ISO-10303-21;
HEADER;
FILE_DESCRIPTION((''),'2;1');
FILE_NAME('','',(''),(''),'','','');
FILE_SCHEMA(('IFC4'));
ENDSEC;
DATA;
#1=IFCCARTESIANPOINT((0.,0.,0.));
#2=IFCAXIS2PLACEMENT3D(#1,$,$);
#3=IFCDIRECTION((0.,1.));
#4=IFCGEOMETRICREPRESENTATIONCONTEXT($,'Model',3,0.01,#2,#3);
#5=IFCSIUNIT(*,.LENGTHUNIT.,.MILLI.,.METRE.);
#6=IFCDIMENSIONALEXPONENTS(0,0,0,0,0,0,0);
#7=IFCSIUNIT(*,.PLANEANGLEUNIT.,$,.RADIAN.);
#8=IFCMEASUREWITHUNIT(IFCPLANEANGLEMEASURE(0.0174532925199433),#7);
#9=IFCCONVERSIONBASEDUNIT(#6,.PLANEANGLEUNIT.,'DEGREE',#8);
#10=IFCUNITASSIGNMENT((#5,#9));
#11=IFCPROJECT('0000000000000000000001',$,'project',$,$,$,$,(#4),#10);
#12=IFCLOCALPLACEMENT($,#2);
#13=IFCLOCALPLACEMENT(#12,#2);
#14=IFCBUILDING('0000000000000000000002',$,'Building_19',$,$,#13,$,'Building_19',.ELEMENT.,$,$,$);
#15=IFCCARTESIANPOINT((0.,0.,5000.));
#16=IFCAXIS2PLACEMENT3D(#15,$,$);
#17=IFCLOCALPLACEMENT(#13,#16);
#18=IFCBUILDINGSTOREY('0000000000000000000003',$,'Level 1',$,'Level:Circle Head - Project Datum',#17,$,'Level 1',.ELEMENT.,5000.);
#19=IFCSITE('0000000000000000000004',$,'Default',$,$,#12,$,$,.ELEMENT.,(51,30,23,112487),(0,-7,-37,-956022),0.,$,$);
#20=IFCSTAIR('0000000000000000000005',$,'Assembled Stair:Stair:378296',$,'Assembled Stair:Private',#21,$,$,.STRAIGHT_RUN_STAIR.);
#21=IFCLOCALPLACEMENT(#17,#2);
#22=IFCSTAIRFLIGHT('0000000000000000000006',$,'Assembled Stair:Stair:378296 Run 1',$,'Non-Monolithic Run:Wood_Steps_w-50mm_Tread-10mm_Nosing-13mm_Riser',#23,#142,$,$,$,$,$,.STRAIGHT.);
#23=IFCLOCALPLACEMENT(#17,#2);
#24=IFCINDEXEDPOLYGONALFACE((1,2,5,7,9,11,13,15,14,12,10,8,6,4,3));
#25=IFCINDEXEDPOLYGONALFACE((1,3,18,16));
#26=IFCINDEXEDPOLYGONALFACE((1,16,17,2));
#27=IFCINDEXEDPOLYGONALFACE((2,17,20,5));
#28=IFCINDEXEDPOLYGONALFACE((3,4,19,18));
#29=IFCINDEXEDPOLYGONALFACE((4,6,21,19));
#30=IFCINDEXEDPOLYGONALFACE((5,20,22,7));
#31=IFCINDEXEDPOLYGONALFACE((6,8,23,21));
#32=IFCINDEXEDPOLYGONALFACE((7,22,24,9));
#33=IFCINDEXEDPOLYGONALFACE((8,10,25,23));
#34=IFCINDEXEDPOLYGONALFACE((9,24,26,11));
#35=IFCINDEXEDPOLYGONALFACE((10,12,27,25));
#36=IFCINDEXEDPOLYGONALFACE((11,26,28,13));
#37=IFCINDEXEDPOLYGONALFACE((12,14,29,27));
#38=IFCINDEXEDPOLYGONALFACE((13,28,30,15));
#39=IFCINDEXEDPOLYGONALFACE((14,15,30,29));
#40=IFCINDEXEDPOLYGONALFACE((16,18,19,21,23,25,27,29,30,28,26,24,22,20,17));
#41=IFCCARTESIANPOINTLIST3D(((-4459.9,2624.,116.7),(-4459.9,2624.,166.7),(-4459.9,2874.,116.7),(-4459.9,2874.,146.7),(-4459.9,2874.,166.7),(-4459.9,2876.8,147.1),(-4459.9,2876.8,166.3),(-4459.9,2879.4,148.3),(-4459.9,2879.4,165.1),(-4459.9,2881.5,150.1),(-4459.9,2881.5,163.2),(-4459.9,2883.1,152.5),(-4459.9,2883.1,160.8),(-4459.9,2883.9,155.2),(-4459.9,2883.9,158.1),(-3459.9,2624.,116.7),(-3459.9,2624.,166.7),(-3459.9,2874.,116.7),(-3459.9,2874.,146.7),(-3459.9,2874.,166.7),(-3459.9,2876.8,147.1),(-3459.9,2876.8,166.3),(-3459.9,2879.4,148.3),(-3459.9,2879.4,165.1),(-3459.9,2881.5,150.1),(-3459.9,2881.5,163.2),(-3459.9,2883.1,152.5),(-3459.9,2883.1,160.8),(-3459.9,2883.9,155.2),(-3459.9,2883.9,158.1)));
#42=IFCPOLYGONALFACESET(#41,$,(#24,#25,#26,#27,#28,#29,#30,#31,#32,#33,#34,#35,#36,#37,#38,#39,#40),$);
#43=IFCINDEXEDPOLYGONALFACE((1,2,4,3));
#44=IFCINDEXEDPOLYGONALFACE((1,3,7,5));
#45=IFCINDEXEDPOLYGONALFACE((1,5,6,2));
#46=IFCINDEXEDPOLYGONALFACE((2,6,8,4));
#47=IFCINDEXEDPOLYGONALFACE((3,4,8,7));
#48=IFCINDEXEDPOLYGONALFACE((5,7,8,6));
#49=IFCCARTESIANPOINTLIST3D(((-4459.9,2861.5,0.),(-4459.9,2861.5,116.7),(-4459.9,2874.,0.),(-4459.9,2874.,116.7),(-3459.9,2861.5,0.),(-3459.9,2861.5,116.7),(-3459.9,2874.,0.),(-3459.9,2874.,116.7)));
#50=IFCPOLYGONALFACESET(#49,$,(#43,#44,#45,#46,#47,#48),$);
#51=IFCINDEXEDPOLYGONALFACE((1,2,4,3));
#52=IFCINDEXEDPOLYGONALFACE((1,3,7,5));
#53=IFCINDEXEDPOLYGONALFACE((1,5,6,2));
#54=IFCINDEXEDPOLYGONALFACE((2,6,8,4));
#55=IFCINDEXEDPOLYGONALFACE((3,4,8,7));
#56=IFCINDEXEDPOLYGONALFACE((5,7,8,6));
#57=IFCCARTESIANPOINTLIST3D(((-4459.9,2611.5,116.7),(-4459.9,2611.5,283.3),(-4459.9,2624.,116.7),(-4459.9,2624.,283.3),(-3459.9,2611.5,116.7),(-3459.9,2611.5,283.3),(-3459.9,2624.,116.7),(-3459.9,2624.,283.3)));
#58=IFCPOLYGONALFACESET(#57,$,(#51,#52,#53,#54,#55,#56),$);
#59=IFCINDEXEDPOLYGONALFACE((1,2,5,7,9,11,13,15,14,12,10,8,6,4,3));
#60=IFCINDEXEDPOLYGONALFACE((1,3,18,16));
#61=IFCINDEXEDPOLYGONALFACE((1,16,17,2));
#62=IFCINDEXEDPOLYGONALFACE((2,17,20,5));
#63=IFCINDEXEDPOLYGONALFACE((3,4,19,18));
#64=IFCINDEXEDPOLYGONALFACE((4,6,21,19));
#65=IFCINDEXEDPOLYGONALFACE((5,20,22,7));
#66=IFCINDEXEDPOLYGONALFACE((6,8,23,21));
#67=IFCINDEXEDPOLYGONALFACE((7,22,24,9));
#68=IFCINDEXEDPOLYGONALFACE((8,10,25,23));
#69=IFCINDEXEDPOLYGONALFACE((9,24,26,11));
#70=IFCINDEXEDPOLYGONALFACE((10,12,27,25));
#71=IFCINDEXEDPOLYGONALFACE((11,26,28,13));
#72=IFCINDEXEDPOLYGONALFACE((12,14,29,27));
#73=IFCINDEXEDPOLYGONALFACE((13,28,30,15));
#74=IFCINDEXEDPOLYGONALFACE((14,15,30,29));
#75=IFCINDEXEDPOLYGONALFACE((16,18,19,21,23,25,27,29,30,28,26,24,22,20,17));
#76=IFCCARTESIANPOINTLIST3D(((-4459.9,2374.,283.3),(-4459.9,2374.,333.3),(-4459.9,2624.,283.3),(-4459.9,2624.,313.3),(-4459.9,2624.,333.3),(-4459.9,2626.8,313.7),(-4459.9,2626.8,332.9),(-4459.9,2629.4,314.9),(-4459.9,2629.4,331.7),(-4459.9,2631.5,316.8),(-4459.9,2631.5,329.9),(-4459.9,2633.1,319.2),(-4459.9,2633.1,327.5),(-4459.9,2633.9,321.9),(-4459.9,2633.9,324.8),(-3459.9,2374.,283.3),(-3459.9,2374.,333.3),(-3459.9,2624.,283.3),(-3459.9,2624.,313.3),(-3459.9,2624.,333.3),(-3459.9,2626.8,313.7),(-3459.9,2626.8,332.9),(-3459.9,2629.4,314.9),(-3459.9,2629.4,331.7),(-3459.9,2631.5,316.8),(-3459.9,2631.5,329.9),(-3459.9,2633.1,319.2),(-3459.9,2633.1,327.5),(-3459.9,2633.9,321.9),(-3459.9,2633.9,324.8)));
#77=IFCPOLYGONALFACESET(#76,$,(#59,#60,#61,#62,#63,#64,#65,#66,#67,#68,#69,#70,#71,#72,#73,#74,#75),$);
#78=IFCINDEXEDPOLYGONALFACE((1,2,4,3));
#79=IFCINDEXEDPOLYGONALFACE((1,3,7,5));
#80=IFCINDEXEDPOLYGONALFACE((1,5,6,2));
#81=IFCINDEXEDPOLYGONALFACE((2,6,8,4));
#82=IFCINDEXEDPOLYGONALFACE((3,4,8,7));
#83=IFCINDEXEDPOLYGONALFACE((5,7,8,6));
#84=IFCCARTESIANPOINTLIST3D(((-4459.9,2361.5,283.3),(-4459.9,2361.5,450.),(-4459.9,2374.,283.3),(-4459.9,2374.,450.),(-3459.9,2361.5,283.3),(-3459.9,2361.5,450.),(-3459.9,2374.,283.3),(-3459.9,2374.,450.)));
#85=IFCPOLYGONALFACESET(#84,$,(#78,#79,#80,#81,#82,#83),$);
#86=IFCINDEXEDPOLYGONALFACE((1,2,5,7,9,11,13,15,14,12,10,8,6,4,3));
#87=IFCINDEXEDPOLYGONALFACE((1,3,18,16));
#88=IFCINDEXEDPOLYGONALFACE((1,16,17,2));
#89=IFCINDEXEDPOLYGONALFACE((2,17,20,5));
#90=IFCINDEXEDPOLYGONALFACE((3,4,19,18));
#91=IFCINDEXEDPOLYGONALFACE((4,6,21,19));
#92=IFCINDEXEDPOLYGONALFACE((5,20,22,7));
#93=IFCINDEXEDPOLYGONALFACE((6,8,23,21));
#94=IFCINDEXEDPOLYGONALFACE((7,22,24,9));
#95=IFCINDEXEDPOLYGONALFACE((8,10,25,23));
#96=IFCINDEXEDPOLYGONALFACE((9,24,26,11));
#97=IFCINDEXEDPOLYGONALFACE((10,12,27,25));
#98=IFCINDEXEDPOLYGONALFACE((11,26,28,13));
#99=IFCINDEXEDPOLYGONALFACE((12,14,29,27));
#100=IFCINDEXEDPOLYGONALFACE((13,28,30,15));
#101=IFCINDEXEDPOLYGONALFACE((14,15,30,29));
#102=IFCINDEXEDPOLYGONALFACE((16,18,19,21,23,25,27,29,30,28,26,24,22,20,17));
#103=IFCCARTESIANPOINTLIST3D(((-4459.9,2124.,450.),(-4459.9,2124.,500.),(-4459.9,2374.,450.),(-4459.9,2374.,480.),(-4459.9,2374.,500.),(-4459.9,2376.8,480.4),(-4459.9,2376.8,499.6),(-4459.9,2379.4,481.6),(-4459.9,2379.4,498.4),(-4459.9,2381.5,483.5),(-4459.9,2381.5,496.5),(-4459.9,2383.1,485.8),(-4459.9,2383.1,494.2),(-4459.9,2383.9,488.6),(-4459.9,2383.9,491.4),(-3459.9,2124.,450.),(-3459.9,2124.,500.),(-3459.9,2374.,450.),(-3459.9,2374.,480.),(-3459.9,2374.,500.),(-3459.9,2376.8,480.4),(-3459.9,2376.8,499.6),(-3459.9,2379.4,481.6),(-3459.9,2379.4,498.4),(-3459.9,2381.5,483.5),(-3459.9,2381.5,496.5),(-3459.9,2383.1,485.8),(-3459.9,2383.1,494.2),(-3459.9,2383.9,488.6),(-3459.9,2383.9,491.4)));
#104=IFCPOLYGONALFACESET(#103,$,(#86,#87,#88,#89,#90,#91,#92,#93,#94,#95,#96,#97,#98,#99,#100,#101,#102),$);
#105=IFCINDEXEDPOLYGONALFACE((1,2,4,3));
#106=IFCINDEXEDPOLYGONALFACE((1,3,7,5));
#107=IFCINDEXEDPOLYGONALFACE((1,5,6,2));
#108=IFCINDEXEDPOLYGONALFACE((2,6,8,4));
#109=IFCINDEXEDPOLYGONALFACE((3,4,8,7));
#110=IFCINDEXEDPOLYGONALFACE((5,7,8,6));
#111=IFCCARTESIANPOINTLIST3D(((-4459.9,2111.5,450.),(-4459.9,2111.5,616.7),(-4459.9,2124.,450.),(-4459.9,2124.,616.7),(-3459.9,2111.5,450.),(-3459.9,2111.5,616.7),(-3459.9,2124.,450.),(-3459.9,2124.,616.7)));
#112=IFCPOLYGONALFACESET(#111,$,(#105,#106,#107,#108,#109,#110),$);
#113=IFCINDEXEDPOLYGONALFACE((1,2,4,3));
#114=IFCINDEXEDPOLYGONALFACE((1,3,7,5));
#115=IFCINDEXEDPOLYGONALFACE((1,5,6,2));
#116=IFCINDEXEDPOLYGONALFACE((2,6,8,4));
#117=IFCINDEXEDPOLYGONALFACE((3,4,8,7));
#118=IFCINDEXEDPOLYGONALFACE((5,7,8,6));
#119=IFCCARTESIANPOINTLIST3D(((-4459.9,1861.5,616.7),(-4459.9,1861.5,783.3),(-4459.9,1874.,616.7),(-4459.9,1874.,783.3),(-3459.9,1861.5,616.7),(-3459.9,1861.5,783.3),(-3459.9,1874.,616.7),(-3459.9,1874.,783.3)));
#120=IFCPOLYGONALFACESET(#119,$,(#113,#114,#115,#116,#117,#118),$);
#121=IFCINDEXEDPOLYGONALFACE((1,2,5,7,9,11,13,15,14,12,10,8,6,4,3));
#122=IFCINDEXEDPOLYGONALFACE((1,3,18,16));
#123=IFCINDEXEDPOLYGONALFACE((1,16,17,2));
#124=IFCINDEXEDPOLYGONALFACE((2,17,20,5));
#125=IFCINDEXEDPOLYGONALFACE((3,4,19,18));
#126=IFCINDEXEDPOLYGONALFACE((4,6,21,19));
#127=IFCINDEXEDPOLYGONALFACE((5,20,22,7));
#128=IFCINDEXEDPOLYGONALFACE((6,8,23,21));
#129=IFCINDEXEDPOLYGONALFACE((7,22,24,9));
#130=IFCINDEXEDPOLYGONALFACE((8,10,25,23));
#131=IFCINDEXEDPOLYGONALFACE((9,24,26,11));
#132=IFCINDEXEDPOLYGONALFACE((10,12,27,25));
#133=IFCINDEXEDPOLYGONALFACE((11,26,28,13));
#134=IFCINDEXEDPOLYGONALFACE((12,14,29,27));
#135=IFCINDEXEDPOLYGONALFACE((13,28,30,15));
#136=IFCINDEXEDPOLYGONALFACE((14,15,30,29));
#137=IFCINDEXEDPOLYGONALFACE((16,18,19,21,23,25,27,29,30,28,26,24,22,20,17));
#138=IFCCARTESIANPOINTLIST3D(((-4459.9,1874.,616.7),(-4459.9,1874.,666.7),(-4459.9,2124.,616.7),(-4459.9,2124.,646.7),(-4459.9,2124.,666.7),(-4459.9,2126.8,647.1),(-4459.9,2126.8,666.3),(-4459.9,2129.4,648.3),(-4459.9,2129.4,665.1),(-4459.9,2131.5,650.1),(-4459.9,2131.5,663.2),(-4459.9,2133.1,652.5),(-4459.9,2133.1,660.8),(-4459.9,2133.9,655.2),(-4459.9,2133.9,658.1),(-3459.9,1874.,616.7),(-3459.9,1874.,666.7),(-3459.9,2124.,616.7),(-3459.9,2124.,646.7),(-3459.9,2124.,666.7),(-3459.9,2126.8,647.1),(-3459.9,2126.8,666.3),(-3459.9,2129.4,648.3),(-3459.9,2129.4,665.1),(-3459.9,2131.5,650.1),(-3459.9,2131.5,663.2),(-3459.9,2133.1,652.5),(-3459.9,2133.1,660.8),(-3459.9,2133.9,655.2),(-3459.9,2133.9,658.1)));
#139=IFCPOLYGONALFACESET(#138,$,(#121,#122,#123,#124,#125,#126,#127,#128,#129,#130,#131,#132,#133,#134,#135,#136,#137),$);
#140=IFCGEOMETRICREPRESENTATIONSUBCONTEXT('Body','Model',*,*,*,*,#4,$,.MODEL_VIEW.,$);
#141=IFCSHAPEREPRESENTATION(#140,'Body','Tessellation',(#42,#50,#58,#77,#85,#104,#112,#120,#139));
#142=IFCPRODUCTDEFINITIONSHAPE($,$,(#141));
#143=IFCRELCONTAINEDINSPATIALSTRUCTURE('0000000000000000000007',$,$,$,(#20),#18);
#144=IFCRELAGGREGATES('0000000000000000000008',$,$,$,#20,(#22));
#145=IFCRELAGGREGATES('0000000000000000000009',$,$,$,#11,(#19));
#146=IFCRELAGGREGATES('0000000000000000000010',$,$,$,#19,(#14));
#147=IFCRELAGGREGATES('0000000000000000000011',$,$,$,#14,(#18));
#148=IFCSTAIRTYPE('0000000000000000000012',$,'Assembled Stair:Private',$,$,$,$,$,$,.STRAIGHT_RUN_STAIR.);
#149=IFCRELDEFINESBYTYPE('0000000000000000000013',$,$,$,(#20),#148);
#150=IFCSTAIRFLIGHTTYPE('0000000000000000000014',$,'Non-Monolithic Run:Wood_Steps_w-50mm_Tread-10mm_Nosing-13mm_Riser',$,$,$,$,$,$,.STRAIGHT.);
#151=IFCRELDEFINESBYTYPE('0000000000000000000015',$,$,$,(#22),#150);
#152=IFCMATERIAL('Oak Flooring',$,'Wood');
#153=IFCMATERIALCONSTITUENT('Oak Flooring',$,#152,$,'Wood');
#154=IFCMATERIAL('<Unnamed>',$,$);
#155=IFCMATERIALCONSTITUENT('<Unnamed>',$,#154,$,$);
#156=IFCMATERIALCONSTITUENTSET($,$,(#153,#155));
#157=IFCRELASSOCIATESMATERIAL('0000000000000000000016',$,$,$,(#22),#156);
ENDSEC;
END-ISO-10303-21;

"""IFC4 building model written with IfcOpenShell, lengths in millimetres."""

from ifc_helpers import new_model, entity, si_unit, converted_unit, direction, frame, origin, place, context, subcontext, project, spatial, line, arc, indexed_curve, outline, extrude, material, constituent, constituent_set, type_object, element, aggregate, save


model = new_model("IFC4")

# Units and contexts
model_context = context("Model", 3, precision=0.01, world=origin(), true_north=direction((0.0, 1.0)))
body_context = subcontext(model_context, "Body", "Model", "MODEL_VIEW")
ifc_project = project(units=[si_unit("LENGTHUNIT", "METRE", prefix="MILLI"), converted_unit("PLANEANGLEUNIT", "DEGREE", entity("IfcPlaneAngleMeasure", 0.0174532925199433), si_unit("PLANEANGLEUNIT", "RADIAN"), dimensions=[0, 0, 0, 0, 0, 0, 0])], contexts=[model_context])

# Site, building, storey
site_placement = place(None, origin())
site = spatial("IfcSite", under=ifc_project, at=site_placement, Name="Default", CompositionType="ELEMENT", RefLatitude=(51, 30, 23, 112487), RefLongitude=(0, -7, -37, -956022), RefElevation=0.0)
building_placement = place(site_placement, origin())
building = spatial("IfcBuilding", under=site, at=building_placement, Name="Building_19", LongName="Building_19", CompositionType="ELEMENT")
storey_placement = place(building_placement, frame((0.0, 0.0, 5000.0)))
storey = spatial("IfcBuildingStorey", under=building, at=storey_placement, Name="Level 1", ObjectType="Level:Circle Head - Project Datum", LongName="Level 1", CompositionType="ELEMENT", Elevation=5000.0)

# Stair
stair_type = type_object("IfcStairType", Name="Assembled Stair:Private", PredefinedType="STRAIGHT_RUN_STAIR")
ifc_material_1 = material(Name="<Unnamed>")
stair_1_placement = place(storey_placement, origin())
stair_1 = element("IfcStair", 1, at=stair_1_placement, inside=storey, type_object=stair_type, Name="Assembled Stair:Stair:378296", ObjectType="Assembled Stair:Private", PredefinedType="STRAIGHT_RUN_STAIR")

# Stair flight
ifc_material_2 = material(Name="Oak Flooring", Category="Wood")
stair_flight_type = type_object("IfcStairFlightType", Name="Non-Monolithic Run:Wood_Steps_w-50mm_Tread-10mm_Nosing-13mm_Riser", PredefinedType="STRAIGHT")
ifc_constituent_1 = constituent(ifc_material_2, Name="Oak Flooring", Category="Wood")
ifc_constituent_2 = constituent(ifc_material_1, Name="<Unnamed>")
ifc_constituent_set_1 = constituent_set(constituents=[ifc_constituent_1, ifc_constituent_2])
stair_flight_1_placement = place(stair_1_placement, origin())
stair_flight_1 = element("IfcStairFlight", 2, at=stair_flight_1_placement, type_object=stair_flight_type, material=ifc_constituent_set_1, Name="Assembled Stair:Stair:378296 Run 1", ObjectType="Non-Monolithic Run:Wood_Steps_w-50mm_Tread-10mm_Nosing-13mm_Riser", PredefinedType="STRAIGHT", context=body_context, shape_type="SweptSolid", body=[
    extrude(outline(indexed_curve([(-24.0, -150.0), (26.0, -150.0), (26.0, 100.0), (-4.0, 100.0), (-14.0, 110.0), (-24.0, 100.0)], segments=[line(1, 2, 3, 4), arc(4, 5, 6), line(6, 1)], self_intersect=False)), frame((-4459.9, 2774.0, 142.7), z_axis=(1.0, 0.0, 0.0), x_axis=(0.0, 0.0, -1.0)), (0.0, 0.0, 1.0), 1000.0),
    extrude(outline(indexed_curve([(-500.0, -6.3), (500.0, -6.3), (500.0, 6.2), (-500.0, 6.2), (-500.0, -6.3)], self_intersect=False)), frame((-3959.9, 2867.7, 0.0)), (0.0, 0.0, 1.0), 116.7),
    extrude(outline(indexed_curve([(-500.0, -6.2), (500.0, -6.2), (500.0, 6.3), (-500.0, 6.3), (-500.0, -6.2)], self_intersect=False)), frame((-3959.9, 2617.7, 116.7)), (0.0, 0.0, 1.0), 166.7),
    extrude(outline(indexed_curve([(-24.0, -150.0), (26.0, -150.0), (26.0, 100.0), (-4.0, 100.0), (-14.0, 110.0), (-24.0, 100.0)], segments=[line(1, 2, 3, 4), arc(4, 5, 6), line(6, 1)], self_intersect=False)), frame((-4459.9, 2524.0, 309.3), z_axis=(1.0, 0.0, 0.0), x_axis=(0.0, 0.0, -1.0)), (0.0, 0.0, 1.0), 1000.0),
    extrude(outline(indexed_curve([(-500.0, -6.2), (500.0, -6.2), (500.0, 6.2), (-500.0, 6.2), (-500.0, -6.2)], self_intersect=False)), frame((-3959.9, 2367.7, 283.3)), (0.0, 0.0, 1.0), 166.7),
    extrude(outline(indexed_curve([(-24.0, -150.0), (26.0, -150.0), (26.0, 100.0), (-4.0, 100.0), (-14.0, 110.0), (-24.0, 100.0)], segments=[line(1, 2, 3, 4), arc(4, 5, 6), line(6, 1)], self_intersect=False)), frame((-4459.9, 2274.0, 476.0), z_axis=(1.0, 0.0, 0.0), x_axis=(0.0, 0.0, -1.0)), (0.0, 0.0, 1.0), 1000.0),
    extrude(outline(indexed_curve([(-500.0, -6.2), (500.0, -6.2), (500.0, 6.3), (-500.0, 6.3), (-500.0, -6.2)], self_intersect=False)), frame((-3959.9, 2117.7, 450.0)), (0.0, 0.0, 1.0), 166.7),
    extrude(outline(indexed_curve([(-500.0, -6.2), (500.0, -6.2), (500.0, 6.2), (-500.0, 6.2), (-500.0, -6.2)], self_intersect=False)), frame((-3959.9, 1867.7, 616.7)), (0.0, 0.0, 1.0), 166.7),
    extrude(outline(indexed_curve([(-24.0, -150.0), (26.0, -150.0), (26.0, 100.0), (-4.0, 100.0), (-14.0, 110.0), (-24.0, 100.0)], segments=[line(1, 2, 3, 4), arc(4, 5, 6), line(6, 1)], self_intersect=False)), frame((-4459.9, 2024.0, 642.7), z_axis=(1.0, 0.0, 0.0), x_axis=(0.0, 0.0, -1.0)), (0.0, 0.0, 1.0), 1000.0),
])

aggregate(stair_1, [stair_flight_1])

save(model, "model.ifc")
